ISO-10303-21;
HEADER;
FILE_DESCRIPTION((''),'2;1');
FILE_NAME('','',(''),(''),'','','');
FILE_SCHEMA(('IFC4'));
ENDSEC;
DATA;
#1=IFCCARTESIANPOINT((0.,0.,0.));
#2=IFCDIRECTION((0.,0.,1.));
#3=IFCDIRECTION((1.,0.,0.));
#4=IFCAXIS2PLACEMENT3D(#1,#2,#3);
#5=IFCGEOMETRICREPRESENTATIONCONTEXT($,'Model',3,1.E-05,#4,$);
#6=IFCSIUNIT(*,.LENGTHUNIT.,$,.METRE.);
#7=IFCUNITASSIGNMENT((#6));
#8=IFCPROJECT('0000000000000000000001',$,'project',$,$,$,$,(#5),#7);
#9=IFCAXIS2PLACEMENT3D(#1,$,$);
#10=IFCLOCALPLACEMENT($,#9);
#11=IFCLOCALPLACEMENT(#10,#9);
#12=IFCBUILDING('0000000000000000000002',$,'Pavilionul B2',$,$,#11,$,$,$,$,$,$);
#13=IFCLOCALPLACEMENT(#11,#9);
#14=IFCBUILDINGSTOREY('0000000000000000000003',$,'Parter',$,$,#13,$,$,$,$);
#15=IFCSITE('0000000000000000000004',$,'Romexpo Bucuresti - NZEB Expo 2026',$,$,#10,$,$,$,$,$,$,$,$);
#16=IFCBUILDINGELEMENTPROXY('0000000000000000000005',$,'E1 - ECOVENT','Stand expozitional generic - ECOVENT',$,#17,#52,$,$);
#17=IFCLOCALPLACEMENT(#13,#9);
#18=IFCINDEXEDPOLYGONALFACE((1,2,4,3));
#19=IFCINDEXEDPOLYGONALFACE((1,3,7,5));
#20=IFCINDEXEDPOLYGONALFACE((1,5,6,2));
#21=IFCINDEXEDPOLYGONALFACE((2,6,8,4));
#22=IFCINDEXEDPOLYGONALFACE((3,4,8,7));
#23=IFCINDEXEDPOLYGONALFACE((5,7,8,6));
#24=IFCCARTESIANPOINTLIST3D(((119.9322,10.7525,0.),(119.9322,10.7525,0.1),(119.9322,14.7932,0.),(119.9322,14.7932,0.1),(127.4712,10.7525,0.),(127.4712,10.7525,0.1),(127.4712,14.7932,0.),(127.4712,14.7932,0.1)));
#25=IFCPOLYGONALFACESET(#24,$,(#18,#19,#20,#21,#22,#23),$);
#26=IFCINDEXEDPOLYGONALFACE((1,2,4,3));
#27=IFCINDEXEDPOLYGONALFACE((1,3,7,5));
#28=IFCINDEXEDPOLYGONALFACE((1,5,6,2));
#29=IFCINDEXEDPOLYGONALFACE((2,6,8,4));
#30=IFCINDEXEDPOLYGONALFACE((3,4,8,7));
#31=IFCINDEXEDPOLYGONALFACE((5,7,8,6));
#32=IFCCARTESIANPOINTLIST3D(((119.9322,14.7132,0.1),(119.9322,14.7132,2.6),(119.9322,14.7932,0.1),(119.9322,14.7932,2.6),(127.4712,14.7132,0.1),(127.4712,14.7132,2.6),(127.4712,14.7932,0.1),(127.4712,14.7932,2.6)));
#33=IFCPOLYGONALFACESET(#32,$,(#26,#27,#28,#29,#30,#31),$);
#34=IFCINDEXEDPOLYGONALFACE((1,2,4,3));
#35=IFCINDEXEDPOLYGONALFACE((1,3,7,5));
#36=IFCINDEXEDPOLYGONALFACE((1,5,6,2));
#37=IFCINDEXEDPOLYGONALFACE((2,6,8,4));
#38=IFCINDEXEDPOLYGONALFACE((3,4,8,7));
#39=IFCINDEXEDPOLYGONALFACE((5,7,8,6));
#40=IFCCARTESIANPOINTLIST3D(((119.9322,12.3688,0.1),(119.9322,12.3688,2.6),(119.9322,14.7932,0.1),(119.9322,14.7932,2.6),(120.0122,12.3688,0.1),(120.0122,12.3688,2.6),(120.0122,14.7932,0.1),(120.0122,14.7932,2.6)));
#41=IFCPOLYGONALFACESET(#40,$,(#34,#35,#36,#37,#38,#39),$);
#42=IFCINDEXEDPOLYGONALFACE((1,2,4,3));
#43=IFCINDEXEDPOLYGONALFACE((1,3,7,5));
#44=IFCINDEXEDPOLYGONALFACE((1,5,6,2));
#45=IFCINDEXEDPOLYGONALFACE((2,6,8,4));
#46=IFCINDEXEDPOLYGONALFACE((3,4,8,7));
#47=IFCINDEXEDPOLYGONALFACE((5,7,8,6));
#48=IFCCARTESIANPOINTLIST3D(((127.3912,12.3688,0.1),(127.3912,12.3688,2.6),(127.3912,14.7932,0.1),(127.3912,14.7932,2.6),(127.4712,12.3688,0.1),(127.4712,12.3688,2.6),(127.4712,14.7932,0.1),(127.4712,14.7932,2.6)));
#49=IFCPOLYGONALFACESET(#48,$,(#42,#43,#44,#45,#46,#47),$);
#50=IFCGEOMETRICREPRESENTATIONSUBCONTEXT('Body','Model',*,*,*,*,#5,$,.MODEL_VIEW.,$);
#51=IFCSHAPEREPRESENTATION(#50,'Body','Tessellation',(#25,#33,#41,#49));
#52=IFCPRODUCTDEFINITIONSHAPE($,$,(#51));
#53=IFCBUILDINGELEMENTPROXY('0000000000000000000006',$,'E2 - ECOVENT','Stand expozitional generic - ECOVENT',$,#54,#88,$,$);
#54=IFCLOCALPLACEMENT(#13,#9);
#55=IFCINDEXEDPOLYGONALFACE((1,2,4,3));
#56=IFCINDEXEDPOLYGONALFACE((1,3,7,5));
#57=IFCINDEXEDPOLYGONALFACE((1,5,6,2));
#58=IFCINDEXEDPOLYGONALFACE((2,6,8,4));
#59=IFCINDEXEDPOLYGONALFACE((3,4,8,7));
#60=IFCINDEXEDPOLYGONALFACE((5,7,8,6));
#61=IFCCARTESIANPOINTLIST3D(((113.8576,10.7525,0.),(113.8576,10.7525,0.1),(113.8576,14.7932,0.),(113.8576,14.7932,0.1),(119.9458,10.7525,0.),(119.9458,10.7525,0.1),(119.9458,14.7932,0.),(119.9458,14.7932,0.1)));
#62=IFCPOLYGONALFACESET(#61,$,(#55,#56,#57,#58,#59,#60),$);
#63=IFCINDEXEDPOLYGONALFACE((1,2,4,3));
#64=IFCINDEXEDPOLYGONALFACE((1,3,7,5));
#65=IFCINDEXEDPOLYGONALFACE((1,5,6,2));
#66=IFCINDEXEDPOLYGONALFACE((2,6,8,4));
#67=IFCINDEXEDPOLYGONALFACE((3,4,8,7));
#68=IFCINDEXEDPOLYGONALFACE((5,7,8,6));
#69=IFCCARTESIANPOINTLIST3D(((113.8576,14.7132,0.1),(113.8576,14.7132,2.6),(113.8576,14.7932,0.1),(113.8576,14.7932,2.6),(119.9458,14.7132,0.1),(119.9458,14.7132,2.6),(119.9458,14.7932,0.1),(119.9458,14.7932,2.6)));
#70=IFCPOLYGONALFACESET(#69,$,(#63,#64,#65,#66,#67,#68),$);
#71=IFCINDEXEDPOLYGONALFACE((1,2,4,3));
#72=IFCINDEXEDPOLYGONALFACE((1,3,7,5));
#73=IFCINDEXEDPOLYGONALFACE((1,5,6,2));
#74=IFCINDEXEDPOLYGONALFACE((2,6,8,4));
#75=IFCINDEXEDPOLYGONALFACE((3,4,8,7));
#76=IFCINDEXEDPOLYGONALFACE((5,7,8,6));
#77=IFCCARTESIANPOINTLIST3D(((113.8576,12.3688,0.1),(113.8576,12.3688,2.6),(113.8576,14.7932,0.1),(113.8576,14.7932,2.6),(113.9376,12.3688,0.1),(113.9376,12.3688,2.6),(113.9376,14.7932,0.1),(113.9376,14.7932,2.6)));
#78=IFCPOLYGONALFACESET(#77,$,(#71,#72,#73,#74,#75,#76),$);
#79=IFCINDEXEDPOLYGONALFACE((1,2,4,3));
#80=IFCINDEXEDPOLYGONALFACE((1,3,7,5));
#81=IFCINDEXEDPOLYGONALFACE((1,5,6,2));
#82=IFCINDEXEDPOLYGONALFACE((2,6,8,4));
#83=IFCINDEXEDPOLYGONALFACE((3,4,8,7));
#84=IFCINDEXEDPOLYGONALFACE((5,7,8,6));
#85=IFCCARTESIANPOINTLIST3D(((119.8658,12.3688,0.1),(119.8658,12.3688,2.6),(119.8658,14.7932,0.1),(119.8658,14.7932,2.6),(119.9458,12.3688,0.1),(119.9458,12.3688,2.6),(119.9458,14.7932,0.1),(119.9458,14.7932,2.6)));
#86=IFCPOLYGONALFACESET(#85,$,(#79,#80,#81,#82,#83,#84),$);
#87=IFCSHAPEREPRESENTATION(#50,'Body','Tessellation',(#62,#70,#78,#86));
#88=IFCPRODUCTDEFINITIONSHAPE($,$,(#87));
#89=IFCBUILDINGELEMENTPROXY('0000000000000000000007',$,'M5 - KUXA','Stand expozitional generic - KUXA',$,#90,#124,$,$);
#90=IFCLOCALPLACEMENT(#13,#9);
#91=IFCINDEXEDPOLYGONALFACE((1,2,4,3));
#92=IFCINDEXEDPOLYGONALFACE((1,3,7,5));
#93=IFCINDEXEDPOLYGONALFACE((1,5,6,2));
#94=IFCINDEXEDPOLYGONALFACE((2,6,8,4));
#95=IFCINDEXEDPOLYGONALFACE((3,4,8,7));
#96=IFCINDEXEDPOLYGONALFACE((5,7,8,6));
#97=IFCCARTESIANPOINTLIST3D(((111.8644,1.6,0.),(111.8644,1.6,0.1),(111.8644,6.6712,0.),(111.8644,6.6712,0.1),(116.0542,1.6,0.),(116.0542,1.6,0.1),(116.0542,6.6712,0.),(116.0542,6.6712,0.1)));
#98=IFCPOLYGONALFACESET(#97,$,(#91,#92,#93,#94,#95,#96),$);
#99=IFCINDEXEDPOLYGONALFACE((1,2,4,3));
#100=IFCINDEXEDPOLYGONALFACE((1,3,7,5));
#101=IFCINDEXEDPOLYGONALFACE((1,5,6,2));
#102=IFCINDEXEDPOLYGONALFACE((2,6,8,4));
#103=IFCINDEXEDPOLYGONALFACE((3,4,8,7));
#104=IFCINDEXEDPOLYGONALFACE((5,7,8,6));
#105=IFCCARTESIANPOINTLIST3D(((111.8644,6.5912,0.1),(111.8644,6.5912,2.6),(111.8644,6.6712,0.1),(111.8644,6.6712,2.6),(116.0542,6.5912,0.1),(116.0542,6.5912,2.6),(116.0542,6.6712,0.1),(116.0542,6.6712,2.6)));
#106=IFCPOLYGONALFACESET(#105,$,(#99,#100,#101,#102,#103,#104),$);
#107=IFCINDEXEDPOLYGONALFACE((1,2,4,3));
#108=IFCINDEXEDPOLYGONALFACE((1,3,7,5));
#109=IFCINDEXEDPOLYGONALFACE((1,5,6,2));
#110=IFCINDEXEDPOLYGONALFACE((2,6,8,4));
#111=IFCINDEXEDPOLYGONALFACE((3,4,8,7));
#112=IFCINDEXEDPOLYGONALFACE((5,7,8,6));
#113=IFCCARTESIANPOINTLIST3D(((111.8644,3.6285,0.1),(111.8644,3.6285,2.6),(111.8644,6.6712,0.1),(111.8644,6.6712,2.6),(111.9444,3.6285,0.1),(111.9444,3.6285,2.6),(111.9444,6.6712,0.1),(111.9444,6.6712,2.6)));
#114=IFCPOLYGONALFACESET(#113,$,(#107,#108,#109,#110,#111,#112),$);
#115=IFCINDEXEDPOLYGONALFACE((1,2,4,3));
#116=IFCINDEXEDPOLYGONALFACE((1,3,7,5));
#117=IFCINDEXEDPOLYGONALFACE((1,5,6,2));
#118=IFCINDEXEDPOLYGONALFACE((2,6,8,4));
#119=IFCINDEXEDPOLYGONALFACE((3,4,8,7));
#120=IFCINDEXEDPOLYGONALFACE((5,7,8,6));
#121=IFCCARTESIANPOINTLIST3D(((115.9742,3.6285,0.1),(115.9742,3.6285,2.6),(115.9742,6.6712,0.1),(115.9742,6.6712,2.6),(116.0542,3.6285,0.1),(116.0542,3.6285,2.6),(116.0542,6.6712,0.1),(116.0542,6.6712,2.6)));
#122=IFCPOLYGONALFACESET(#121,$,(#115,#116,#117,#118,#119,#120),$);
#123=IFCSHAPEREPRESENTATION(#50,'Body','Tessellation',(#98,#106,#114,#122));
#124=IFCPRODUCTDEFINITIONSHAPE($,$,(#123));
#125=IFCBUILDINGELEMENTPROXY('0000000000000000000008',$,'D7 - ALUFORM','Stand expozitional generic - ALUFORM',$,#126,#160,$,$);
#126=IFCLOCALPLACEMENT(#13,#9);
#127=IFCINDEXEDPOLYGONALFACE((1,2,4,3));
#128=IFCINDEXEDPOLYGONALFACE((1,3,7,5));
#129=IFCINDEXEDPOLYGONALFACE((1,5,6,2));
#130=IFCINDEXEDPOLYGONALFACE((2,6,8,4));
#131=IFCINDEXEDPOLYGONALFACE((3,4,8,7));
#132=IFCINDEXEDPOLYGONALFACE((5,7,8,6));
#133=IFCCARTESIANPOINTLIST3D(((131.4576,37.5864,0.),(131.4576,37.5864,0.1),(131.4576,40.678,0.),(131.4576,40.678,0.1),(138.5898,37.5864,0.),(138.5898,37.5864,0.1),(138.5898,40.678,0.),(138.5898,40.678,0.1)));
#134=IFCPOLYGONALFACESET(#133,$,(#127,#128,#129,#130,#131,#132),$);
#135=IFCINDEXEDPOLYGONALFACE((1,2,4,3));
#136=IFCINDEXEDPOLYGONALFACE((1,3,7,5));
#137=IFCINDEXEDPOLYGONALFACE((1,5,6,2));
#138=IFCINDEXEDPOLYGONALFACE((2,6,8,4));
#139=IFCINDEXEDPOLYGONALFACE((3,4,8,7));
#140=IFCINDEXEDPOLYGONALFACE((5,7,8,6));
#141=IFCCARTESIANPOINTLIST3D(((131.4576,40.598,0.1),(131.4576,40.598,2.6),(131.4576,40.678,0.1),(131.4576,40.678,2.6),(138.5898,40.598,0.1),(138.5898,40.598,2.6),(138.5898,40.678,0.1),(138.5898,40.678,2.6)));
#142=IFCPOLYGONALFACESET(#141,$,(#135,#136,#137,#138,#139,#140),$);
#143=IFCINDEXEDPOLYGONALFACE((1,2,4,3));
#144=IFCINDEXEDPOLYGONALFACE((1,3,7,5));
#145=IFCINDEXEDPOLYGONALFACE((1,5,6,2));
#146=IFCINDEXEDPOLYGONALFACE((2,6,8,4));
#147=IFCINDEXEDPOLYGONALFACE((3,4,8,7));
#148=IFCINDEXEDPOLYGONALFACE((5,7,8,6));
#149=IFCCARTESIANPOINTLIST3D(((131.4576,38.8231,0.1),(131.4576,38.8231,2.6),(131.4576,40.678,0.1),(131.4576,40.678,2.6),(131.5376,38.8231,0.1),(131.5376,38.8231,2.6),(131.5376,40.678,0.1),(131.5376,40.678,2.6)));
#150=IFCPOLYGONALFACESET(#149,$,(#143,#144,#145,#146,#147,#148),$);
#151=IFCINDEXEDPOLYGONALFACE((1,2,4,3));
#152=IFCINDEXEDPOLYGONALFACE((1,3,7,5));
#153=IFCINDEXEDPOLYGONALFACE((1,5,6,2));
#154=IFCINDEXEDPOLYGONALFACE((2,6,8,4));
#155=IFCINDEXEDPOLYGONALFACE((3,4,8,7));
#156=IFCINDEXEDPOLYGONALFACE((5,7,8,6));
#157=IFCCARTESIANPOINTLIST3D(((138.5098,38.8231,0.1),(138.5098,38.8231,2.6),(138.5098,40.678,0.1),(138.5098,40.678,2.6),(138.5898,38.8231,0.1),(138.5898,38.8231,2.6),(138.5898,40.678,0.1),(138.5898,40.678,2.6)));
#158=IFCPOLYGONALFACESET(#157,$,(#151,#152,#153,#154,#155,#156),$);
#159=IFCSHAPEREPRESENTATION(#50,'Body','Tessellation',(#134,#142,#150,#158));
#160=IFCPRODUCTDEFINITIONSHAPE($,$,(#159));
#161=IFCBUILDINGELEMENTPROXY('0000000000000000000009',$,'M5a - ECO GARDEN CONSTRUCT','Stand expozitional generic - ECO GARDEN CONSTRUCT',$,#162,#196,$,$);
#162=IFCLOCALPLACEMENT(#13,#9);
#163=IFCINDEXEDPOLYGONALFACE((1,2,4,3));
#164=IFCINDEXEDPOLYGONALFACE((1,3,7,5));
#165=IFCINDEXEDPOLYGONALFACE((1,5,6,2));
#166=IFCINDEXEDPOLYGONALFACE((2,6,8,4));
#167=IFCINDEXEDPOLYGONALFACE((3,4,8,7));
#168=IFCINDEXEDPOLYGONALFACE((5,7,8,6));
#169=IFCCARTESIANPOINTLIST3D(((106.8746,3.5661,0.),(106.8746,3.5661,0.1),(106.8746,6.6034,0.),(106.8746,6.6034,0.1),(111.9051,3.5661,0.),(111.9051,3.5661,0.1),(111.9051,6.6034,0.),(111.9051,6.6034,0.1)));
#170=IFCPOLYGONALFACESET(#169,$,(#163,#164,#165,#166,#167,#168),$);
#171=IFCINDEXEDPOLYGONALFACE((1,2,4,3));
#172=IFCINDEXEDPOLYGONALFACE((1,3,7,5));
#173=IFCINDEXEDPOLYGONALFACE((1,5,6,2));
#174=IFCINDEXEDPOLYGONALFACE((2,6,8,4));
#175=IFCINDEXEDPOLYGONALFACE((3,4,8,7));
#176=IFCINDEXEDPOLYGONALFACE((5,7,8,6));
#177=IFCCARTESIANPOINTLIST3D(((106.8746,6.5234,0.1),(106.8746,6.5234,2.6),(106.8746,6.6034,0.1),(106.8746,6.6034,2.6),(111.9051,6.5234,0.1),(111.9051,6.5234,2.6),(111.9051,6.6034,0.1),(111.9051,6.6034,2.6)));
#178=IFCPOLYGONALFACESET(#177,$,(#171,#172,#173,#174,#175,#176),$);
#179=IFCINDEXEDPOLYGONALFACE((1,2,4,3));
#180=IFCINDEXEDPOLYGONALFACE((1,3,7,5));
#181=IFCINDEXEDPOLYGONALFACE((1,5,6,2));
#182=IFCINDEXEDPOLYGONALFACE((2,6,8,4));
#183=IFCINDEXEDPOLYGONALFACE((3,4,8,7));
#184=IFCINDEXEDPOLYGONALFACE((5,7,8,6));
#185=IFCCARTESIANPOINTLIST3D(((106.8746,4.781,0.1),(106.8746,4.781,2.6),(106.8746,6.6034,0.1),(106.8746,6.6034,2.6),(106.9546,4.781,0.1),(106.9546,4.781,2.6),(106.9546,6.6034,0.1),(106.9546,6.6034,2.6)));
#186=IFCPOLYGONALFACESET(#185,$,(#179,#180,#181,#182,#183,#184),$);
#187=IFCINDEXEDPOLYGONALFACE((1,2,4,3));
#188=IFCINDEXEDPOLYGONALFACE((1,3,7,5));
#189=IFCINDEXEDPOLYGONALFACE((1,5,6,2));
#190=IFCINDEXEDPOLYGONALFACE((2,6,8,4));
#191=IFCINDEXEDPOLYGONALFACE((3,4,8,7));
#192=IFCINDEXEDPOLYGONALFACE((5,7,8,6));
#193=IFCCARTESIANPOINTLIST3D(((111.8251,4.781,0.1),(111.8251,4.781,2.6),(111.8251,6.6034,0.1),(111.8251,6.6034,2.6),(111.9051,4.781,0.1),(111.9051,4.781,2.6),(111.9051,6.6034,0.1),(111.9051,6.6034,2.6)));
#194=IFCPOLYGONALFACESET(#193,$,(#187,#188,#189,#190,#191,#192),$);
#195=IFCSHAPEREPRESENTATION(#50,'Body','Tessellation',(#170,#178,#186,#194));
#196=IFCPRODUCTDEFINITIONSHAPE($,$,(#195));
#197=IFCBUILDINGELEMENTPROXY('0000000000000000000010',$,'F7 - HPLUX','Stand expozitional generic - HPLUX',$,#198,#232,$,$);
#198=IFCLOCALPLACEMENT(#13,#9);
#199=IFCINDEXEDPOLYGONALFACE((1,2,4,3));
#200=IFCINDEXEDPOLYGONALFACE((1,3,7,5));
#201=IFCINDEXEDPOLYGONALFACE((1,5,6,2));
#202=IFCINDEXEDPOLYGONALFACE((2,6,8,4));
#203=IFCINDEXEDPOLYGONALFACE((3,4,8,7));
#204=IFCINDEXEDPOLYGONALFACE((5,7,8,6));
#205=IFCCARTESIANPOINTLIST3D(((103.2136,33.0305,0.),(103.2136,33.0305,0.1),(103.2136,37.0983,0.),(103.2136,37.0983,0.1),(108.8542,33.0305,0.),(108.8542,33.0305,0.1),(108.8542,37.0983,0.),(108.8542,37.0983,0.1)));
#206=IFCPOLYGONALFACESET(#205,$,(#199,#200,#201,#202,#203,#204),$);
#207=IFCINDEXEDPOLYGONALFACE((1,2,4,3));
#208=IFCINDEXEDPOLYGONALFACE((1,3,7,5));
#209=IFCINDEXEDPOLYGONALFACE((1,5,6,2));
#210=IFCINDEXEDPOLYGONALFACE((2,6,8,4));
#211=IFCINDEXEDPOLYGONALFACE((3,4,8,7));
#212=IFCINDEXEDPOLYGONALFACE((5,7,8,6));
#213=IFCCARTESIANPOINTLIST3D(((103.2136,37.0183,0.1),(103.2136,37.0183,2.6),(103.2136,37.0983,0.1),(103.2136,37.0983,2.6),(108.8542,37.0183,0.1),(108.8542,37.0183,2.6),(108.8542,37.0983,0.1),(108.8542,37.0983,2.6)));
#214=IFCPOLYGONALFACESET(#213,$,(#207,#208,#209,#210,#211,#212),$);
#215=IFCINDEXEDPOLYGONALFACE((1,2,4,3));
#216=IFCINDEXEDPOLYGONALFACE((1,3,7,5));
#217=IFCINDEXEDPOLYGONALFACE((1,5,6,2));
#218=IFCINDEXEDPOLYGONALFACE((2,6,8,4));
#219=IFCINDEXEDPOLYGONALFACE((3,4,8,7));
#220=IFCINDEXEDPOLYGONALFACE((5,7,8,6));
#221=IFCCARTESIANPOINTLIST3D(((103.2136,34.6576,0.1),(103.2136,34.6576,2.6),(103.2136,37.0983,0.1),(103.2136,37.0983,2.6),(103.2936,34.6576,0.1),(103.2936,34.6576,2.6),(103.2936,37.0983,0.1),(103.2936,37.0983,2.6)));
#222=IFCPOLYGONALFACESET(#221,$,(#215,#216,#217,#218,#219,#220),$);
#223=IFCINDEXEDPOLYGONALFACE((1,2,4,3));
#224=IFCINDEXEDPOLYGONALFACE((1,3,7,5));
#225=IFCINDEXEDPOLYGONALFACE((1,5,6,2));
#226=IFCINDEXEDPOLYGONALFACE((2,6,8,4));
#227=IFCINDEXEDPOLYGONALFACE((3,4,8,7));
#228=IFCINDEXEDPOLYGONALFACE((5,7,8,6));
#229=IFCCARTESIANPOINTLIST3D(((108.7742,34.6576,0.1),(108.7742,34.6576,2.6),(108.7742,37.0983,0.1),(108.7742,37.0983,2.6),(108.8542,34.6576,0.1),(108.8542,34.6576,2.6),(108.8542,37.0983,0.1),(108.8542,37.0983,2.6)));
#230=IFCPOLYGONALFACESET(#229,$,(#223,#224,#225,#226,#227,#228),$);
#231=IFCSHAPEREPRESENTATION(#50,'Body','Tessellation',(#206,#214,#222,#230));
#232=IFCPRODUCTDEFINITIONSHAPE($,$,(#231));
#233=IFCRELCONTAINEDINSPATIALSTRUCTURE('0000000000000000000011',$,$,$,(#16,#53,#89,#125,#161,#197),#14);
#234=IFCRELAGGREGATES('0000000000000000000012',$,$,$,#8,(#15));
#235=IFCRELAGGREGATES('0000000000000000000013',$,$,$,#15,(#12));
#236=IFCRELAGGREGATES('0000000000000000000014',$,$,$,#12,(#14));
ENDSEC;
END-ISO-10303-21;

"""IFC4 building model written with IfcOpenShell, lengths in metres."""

from ifc_helpers import new_model, si_unit, frame, frame_2d, origin, origin_with_axes, place, context, subcontext, project, spatial, rectangle, extrude, element, save


model = new_model("IFC4")

# Units and contexts
model_context = context("Model", 3, precision=1e-05, world=origin_with_axes())
body_context = subcontext(model_context, "Body", "Model", "MODEL_VIEW")
ifc_project = project(units=[si_unit("LENGTHUNIT", "METRE")], contexts=[model_context])

# Site, building, storey
site_placement = place(None, origin())
site = spatial("IfcSite", under=ifc_project, at=site_placement, Name="Romexpo Bucuresti - NZEB Expo 2026")
building_placement = place(site_placement, origin())
building = spatial("IfcBuilding", under=site, at=building_placement, Name="Pavilionul B2")
storey_placement = place(building_placement, origin())
storey = spatial("IfcBuildingStorey", under=building, at=storey_placement, Name="Parter")

# Building element proxies
proxy_1_placement = place(storey_placement, frame((119.9322, 10.7525, 0.0), z_axis=(0.0, 0.0, 1.0), x_axis=(1.0, 0.0, 0.0)))
element("IfcBuildingElementProxy", 1, at=proxy_1_placement, inside=storey, Name="E1 - ECOVENT", Description="Stand expozitional generic - ECOVENT", context=body_context, shape_type="SweptSolid", body=[
    extrude(rectangle(XDim=7.539, YDim=4.0407, at=frame_2d((3.7695, 2.0203))), origin(), (0.0, 0.0, 1.0), 0.1),
    extrude(rectangle(XDim=7.539, YDim=0.08, at=frame_2d((3.7695, 4.0007))), frame((0.0, 0.0, 0.1)), (0.0, 0.0, 1.0), 2.5),
    extrude(rectangle(XDim=0.08, YDim=2.4244, at=frame_2d((0.04, 2.8285))), frame((0.0, 0.0, 0.1)), (0.0, 0.0, 1.0), 2.5),
    extrude(rectangle(XDim=0.08, YDim=2.4244, at=frame_2d((7.499, 2.8285))), frame((0.0, 0.0, 0.1)), (0.0, 0.0, 1.0), 2.5),
])
proxy_2_placement = place(storey_placement, frame((113.8576, 10.7525, 0.0), z_axis=(0.0, 0.0, 1.0), x_axis=(1.0, 0.0, 0.0)))
element("IfcBuildingElementProxy", 2, at=proxy_2_placement, inside=storey, Name="E2 - ECOVENT", Description="Stand expozitional generic - ECOVENT", context=body_context, shape_type="SweptSolid", body=[
    extrude(rectangle(XDim=6.0881, YDim=4.0407, at=frame_2d((3.0441, 2.0203))), origin(), (0.0, 0.0, 1.0), 0.1),
    extrude(rectangle(XDim=6.0881, YDim=0.08, at=frame_2d((3.0441, 4.0007))), frame((0.0, 0.0, 0.1)), (0.0, 0.0, 1.0), 2.5),
    extrude(rectangle(XDim=0.08, YDim=2.4244, at=frame_2d((0.04, 2.8285))), frame((0.0, 0.0, 0.1)), (0.0, 0.0, 1.0), 2.5),
    extrude(rectangle(XDim=0.08, YDim=2.4244, at=frame_2d((6.0481, 2.8285))), frame((0.0, 0.0, 0.1)), (0.0, 0.0, 1.0), 2.5),
])
proxy_3_placement = place(storey_placement, frame((111.8644, 1.6, 0.0), z_axis=(0.0, 0.0, 1.0), x_axis=(1.0, 0.0, 0.0)))
element("IfcBuildingElementProxy", 3, at=proxy_3_placement, inside=storey, Name="M5 - KUXA", Description="Stand expozitional generic - KUXA", context=body_context, shape_type="SweptSolid", body=[
    extrude(rectangle(XDim=4.1898, YDim=5.0712, at=frame_2d((2.0949, 2.5356))), origin(), (0.0, 0.0, 1.0), 0.1),
    extrude(rectangle(XDim=4.1898, YDim=0.08, at=frame_2d((2.0949, 5.0312))), frame((0.0, 0.0, 0.1)), (0.0, 0.0, 1.0), 2.5),
    extrude(rectangle(XDim=0.08, YDim=3.0427, at=frame_2d((0.04, 3.5498))), frame((0.0, 0.0, 0.1)), (0.0, 0.0, 1.0), 2.5),
    extrude(rectangle(XDim=0.08, YDim=3.0427, at=frame_2d((4.1498, 3.5498))), frame((0.0, 0.0, 0.1)), (0.0, 0.0, 1.0), 2.5),
])
proxy_4_placement = place(storey_placement, frame((131.4576, 37.5864, 0.0), z_axis=(0.0, 0.0, 1.0), x_axis=(1.0, 0.0, 0.0)))
element("IfcBuildingElementProxy", 4, at=proxy_4_placement, inside=storey, Name="D7 - ALUFORM", Description="Stand expozitional generic - ALUFORM", context=body_context, shape_type="SweptSolid", body=[
    extrude(rectangle(XDim=7.1322, YDim=3.0915, at=frame_2d((3.5661, 1.5458))), origin(), (0.0, 0.0, 1.0), 0.1),
    extrude(rectangle(XDim=7.1322, YDim=0.08, at=frame_2d((3.5661, 3.0515))), frame((0.0, 0.0, 0.1)), (0.0, 0.0, 1.0), 2.5),
    extrude(rectangle(XDim=0.08, YDim=1.8549, at=frame_2d((0.04, 2.1641))), frame((0.0, 0.0, 0.1)), (0.0, 0.0, 1.0), 2.5),
    extrude(rectangle(XDim=0.08, YDim=1.8549, at=frame_2d((7.0922, 2.1641))), frame((0.0, 0.0, 0.1)), (0.0, 0.0, 1.0), 2.5),
])
proxy_5_placement = place(storey_placement, frame((106.8746, 3.5661, 0.0), z_axis=(0.0, 0.0, 1.0), x_axis=(1.0, 0.0, 0.0)))
element("IfcBuildingElementProxy", 5, at=proxy_5_placement, inside=storey, Name="M5a - ECO GARDEN CONSTRUCT", Description="Stand expozitional generic - ECO GARDEN CONSTRUCT", context=body_context, shape_type="SweptSolid", body=[
    extrude(rectangle(XDim=5.0305, YDim=3.0373, at=frame_2d((2.5153, 1.5186))), origin(), (0.0, 0.0, 1.0), 0.1),
    extrude(rectangle(XDim=5.0305, YDim=0.08, at=frame_2d((2.5153, 2.9973))), frame((0.0, 0.0, 0.1)), (0.0, 0.0, 1.0), 2.5),
    extrude(rectangle(XDim=0.08, YDim=1.8224, at=frame_2d((0.04, 2.1261))), frame((0.0, 0.0, 0.1)), (0.0, 0.0, 1.0), 2.5),
    extrude(rectangle(XDim=0.08, YDim=1.8224, at=frame_2d((4.9905, 2.1261))), frame((0.0, 0.0, 0.1)), (0.0, 0.0, 1.0), 2.5),
])
for number, where, z_axis, x_axis, name in (
    (6, (103.2136, 33.0305, 0.0), (0.0, 0.0, 1.0), (1.0, 0.0, 0.0), "F7 - HPLUX"),
):
    element("IfcBuildingElementProxy", number, at=place(storey_placement, frame(where, z_axis=z_axis, x_axis=x_axis)), inside=storey, Name=name, Description="Stand expozitional generic - HPLUX", context=body_context, shape_type="SweptSolid", body=[
        extrude(rectangle(XDim=5.6407, YDim=4.0678, at=frame_2d((2.8203, 2.0339))), origin(), (0.0, 0.0, 1.0), 0.1),
        extrude(rectangle(XDim=5.6407, YDim=0.08, at=frame_2d((2.8203, 4.0278))), frame((0.0, 0.0, 0.1)), (0.0, 0.0, 1.0), 2.5),
        extrude(rectangle(XDim=0.08, YDim=2.4407, at=frame_2d((0.04, 2.8475))), frame((0.0, 0.0, 0.1)), (0.0, 0.0, 1.0), 2.5),
        extrude(rectangle(XDim=0.08, YDim=2.4407, at=frame_2d((5.6007, 2.8475))), frame((0.0, 0.0, 0.1)), (0.0, 0.0, 1.0), 2.5),
    ])

save(model, "model.ifc")
